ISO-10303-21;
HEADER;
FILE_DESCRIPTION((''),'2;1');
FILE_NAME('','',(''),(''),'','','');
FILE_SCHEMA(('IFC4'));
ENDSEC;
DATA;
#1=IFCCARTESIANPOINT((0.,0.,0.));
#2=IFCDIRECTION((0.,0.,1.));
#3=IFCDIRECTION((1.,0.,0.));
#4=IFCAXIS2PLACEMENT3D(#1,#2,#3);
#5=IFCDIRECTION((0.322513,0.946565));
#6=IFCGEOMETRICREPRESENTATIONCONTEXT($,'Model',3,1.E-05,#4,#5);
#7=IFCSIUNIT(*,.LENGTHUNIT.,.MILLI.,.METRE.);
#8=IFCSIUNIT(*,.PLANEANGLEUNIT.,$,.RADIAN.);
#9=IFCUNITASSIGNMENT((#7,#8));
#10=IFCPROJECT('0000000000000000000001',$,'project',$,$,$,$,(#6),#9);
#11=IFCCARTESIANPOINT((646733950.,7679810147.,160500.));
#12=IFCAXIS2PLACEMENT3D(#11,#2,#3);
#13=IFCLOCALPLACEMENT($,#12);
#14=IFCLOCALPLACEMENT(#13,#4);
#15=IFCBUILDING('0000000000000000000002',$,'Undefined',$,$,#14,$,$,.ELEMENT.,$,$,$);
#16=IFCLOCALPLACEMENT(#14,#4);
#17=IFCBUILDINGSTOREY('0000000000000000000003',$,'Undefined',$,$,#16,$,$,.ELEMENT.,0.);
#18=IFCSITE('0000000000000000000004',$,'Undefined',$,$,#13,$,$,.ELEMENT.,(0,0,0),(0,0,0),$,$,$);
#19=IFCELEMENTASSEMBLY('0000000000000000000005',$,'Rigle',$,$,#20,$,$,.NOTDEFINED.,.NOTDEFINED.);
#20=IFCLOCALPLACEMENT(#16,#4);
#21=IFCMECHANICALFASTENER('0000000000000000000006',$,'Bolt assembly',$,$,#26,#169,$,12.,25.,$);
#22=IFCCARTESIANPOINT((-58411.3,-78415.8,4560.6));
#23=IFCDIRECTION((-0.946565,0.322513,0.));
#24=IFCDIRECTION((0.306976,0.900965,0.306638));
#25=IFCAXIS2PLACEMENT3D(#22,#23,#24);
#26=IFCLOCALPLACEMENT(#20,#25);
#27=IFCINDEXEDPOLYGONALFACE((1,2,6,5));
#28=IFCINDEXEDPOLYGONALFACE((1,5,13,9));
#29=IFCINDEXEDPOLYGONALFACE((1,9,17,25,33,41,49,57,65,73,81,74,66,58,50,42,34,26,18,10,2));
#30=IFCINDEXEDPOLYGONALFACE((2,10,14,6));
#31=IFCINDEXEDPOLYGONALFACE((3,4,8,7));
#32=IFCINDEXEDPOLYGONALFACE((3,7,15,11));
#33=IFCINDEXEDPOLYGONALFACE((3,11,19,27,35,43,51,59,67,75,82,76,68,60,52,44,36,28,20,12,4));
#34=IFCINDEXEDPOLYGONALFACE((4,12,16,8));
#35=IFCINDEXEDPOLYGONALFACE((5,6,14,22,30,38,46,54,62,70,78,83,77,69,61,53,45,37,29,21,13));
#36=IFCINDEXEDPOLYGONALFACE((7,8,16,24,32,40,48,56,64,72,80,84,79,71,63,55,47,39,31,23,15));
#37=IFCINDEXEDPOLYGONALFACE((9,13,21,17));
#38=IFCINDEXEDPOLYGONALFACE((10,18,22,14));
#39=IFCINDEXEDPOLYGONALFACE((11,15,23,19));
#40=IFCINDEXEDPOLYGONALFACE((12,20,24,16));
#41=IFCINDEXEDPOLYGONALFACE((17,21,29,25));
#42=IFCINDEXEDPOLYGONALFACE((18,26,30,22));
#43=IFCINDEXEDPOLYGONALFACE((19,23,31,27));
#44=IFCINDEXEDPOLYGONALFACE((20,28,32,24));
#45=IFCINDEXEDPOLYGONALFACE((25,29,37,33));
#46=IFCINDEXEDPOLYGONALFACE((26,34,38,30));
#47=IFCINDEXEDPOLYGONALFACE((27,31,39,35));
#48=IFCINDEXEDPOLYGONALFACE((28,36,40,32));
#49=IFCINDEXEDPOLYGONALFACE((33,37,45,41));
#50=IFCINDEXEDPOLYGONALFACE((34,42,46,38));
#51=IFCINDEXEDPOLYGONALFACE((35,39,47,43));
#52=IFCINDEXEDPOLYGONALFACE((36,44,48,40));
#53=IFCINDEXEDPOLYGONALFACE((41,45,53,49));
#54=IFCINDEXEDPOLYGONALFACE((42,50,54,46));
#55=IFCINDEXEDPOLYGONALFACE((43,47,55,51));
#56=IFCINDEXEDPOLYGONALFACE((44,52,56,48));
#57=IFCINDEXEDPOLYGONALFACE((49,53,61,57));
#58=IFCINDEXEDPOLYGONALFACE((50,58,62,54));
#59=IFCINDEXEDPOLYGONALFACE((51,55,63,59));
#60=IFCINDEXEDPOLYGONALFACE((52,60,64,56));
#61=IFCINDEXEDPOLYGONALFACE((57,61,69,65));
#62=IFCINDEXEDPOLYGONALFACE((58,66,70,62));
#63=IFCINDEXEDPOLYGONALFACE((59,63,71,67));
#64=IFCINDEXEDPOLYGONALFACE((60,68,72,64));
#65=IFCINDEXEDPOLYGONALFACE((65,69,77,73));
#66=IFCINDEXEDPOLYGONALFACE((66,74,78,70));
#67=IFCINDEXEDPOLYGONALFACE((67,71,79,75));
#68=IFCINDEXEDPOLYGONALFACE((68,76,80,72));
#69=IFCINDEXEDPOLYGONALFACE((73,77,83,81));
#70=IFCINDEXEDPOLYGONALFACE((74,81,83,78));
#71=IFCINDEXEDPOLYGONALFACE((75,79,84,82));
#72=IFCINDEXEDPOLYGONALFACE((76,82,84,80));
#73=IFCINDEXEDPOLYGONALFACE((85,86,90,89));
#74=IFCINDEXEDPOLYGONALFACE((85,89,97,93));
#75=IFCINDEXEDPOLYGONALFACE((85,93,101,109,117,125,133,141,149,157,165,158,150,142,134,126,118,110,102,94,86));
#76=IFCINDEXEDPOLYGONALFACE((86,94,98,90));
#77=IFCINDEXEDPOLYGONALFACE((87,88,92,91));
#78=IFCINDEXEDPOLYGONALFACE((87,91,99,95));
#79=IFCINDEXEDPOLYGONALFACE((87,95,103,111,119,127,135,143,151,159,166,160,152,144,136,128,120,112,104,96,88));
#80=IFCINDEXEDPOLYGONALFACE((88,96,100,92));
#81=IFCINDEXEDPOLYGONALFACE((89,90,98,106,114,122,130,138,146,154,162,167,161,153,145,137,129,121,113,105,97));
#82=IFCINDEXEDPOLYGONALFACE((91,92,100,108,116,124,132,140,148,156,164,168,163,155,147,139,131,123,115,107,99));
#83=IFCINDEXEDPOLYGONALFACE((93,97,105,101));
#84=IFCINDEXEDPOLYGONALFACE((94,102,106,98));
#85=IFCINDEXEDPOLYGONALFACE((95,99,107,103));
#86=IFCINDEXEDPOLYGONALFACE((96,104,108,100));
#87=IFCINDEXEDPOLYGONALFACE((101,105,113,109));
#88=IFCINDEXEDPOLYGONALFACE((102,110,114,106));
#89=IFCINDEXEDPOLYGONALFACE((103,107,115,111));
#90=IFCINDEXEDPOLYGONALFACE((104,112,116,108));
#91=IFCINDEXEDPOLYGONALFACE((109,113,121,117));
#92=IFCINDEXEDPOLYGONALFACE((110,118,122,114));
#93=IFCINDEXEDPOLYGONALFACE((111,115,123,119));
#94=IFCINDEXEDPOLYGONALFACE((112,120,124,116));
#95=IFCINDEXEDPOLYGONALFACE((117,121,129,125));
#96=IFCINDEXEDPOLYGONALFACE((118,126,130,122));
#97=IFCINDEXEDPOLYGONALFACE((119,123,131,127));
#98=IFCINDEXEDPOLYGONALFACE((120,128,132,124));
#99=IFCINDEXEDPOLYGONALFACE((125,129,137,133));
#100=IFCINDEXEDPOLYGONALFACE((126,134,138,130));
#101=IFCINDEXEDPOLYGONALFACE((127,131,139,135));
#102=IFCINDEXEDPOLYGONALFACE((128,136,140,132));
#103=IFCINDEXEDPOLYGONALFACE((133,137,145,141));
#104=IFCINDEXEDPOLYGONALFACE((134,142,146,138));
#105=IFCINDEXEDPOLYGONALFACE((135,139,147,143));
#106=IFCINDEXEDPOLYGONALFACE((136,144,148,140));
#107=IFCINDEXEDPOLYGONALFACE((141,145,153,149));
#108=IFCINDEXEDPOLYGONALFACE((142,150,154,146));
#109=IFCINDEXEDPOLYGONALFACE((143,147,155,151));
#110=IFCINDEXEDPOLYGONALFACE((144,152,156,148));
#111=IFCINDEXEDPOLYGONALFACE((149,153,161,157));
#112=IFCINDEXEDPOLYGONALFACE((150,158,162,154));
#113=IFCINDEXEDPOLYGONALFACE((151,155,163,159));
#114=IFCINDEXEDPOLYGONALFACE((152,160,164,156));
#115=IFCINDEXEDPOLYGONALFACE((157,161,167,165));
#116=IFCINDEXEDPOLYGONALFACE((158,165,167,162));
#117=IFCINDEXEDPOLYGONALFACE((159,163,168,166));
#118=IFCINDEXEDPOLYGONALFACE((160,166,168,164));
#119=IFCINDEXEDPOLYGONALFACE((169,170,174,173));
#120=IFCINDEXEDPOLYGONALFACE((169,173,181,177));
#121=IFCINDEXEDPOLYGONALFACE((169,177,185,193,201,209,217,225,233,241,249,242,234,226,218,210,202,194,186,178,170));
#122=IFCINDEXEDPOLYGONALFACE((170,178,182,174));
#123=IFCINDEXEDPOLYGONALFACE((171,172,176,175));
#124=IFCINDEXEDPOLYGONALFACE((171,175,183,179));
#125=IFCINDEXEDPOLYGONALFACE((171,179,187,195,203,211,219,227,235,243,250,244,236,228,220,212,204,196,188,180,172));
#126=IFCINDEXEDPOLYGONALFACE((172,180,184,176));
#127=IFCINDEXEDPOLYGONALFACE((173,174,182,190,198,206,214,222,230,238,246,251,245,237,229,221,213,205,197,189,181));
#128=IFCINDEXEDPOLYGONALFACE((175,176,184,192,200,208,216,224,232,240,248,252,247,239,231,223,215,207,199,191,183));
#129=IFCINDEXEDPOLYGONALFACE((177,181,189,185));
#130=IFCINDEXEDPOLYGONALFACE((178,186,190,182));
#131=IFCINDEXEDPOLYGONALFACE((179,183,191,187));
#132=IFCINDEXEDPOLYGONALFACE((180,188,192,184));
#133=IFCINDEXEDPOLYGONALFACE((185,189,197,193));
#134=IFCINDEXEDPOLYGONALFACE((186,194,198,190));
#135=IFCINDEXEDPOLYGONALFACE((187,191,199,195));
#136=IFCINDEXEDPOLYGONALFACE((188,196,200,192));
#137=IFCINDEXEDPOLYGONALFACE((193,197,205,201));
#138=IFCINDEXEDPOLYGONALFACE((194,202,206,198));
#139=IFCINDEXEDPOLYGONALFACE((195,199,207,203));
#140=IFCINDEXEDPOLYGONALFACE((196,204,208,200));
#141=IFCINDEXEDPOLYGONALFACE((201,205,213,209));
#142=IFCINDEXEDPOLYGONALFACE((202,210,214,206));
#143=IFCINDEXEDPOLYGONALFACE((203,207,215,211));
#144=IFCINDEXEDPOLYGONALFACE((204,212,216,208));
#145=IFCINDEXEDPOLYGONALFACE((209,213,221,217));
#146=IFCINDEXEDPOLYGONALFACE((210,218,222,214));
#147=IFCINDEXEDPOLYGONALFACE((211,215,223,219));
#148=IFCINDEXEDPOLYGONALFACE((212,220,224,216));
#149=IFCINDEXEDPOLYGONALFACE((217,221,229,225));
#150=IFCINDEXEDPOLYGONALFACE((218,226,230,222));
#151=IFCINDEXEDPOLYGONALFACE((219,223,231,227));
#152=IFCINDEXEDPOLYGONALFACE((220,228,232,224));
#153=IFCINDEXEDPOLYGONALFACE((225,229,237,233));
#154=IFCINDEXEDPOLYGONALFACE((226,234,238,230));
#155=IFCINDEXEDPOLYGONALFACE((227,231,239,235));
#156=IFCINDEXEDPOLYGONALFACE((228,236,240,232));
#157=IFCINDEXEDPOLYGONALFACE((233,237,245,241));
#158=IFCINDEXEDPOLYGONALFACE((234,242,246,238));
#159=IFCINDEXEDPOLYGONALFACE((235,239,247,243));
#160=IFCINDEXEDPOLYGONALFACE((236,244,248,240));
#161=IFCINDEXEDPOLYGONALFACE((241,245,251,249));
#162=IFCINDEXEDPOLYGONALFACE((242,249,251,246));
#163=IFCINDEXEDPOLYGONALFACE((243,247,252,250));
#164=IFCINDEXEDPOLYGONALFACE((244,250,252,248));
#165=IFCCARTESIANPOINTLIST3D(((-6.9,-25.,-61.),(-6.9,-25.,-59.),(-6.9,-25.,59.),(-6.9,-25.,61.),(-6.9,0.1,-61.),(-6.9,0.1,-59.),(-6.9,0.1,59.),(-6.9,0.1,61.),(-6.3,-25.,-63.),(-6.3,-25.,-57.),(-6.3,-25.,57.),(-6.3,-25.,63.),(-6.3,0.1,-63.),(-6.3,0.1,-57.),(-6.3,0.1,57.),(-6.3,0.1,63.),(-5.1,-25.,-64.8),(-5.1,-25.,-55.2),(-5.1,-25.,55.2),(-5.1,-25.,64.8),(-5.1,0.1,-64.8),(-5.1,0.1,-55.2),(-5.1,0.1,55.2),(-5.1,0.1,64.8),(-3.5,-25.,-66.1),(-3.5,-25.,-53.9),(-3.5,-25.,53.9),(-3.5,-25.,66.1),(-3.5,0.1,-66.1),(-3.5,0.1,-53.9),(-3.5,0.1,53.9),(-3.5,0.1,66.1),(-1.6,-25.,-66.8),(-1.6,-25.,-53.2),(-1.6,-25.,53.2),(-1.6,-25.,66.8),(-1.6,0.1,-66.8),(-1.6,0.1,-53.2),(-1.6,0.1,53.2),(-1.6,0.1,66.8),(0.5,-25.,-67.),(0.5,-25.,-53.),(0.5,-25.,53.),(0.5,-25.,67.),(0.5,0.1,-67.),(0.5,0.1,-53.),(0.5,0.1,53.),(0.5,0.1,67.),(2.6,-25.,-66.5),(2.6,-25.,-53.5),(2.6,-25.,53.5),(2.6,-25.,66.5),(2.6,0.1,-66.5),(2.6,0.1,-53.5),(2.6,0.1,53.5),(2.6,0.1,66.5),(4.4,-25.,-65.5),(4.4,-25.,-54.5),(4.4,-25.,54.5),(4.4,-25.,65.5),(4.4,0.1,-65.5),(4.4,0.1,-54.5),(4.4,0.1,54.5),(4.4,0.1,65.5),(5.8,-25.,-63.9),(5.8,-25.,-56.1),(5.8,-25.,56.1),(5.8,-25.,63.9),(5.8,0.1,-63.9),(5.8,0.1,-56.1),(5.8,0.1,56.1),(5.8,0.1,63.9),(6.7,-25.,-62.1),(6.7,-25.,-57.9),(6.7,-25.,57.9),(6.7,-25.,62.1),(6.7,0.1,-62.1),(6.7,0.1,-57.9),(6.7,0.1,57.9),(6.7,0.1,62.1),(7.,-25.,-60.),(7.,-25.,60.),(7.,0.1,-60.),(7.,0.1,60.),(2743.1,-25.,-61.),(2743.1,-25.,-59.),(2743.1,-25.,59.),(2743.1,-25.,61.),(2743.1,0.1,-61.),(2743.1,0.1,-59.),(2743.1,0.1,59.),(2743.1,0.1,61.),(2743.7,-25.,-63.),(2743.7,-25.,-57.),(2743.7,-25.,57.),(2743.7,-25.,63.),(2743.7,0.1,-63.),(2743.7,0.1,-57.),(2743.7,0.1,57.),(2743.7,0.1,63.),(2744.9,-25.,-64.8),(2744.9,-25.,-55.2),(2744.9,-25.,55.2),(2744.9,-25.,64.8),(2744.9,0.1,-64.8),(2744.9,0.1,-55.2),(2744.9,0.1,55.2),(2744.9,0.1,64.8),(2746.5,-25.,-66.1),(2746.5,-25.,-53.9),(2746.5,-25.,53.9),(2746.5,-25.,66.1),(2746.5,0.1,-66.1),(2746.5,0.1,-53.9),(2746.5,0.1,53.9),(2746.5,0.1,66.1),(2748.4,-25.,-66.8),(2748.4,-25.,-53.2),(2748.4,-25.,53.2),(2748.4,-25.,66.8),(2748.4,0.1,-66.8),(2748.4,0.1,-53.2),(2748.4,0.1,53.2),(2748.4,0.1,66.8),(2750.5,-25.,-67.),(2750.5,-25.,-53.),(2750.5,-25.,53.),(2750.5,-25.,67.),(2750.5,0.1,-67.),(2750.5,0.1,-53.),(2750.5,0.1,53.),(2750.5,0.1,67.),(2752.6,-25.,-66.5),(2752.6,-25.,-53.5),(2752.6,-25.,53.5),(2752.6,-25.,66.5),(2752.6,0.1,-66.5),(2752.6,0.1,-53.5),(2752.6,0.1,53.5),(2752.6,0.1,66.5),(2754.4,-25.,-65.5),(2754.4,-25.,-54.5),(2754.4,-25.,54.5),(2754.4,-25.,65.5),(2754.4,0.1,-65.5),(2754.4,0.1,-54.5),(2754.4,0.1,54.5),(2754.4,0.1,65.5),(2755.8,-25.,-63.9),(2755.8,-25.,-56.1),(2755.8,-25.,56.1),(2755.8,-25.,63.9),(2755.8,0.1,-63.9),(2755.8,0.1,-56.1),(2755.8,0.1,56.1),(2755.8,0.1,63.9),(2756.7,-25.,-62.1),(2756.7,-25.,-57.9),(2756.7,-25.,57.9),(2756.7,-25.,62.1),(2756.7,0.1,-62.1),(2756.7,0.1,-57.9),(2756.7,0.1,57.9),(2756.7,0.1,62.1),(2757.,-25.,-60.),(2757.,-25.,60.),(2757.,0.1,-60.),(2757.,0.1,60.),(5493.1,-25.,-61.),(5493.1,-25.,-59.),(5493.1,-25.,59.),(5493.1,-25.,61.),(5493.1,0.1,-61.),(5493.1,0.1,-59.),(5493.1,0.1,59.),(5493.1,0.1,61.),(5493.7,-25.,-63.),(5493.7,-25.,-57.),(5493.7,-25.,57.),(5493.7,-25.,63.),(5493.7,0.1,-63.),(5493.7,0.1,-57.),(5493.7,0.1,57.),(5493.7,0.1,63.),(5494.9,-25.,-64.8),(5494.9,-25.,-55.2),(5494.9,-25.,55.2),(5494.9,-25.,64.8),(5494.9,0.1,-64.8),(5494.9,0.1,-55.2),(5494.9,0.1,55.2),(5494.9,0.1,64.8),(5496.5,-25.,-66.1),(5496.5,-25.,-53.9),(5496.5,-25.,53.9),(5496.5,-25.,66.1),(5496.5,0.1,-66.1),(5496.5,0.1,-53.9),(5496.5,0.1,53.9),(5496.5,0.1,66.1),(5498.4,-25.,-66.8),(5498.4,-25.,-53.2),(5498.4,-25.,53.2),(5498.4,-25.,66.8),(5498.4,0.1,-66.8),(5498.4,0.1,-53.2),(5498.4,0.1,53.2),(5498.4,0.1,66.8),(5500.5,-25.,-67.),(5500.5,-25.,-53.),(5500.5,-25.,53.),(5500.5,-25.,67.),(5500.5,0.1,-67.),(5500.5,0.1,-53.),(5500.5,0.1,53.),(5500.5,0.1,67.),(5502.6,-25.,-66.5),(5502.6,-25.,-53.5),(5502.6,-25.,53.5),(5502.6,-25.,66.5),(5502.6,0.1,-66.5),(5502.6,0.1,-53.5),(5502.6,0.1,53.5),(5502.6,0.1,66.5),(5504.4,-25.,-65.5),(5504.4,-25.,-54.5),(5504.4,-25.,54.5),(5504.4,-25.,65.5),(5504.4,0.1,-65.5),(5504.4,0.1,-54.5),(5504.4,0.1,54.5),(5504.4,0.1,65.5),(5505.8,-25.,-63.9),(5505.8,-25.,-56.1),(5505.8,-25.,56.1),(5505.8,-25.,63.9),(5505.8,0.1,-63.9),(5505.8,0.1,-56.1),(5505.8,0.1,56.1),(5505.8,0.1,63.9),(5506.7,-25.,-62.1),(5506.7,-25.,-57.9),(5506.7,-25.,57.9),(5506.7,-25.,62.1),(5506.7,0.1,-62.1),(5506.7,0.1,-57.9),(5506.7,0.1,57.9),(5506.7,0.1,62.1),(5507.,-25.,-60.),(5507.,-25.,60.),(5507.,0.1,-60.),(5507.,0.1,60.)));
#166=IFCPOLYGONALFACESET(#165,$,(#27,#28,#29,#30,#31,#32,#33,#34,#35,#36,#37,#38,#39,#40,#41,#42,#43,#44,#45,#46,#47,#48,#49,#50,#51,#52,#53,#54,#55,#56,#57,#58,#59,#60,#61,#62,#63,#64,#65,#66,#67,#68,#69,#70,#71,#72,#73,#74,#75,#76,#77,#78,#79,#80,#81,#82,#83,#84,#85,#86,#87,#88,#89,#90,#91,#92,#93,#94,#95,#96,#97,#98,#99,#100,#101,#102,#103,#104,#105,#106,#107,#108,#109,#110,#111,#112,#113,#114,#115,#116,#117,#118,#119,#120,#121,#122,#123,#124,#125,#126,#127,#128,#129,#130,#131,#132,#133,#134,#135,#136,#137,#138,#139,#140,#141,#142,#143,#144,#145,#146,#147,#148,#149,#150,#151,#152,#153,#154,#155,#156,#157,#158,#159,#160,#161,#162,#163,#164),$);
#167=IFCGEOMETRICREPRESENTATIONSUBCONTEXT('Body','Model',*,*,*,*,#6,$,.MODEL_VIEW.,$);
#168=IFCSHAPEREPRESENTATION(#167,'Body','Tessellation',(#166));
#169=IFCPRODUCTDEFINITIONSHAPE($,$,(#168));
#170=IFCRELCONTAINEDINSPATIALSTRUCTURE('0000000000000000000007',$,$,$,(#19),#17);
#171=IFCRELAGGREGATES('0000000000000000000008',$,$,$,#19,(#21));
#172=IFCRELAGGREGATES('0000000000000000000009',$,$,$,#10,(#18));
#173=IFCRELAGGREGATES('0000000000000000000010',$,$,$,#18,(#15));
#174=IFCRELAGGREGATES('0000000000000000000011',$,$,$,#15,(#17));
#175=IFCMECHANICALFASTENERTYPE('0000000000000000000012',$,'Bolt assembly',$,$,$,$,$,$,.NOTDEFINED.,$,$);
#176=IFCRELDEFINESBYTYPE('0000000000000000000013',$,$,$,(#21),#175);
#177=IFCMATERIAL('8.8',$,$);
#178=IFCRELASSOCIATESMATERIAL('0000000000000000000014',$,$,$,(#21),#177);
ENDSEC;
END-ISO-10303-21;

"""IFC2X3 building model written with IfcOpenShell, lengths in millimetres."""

from ifc_helpers import new_model, si_unit, direction, frame, origin_with_axes, origin_2d_with_axis, place, context, subcontext, project, spatial, circle, extrude, source, transform, mapped, material, type_object, element, aggregate, save


model = new_model("IFC2X3")

# Units and contexts
model_context = context("Model", 3, precision=1e-05, world=origin_with_axes(), true_north=direction((0.322513, 0.946565)))
body_context = subcontext(model_context, "Body", "Model", "MODEL_VIEW")
ifc_project = project(units=[si_unit("LENGTHUNIT", "METRE", prefix="MILLI"), si_unit("PLANEANGLEUNIT", "RADIAN")], contexts=[model_context])

# Site, building, storey
site_placement = place(None, frame((646733950.0, 7679810147.0, 160500.0), z_axis=(0.0, 0.0, 1.0), x_axis=(1.0, 0.0, 0.0)))
site = spatial("IfcSite", under=ifc_project, at=site_placement, Name="Undefined", CompositionType="ELEMENT", RefLatitude=(0, 0, 0), RefLongitude=(0, 0, 0))
building_placement = place(site_placement, origin_with_axes())
building = spatial("IfcBuilding", under=site, at=building_placement, Name="Undefined", CompositionType="ELEMENT")
storey_placement = place(building_placement, origin_with_axes())
storey = spatial("IfcBuildingStorey", under=building, at=storey_placement, Name="Undefined", CompositionType="ELEMENT", Elevation=0.0)

# Element assembly
assembly_1_placement = place(storey_placement, origin_with_axes())
assembly_1 = element("IfcElementAssembly", 1, at=assembly_1_placement, inside=storey, Name="Rigle", AssemblyPlace="NOTDEFINED", PredefinedType="NOTDEFINED")

# Shared definitions
ifc_material_1 = material(Name="8.8")
mechanical_fastener_type = type_object("IfcMechanicalFastenerType", Name="Bolt assembly")

# Mechanical fastener
shared_shape_1 = source(origin_with_axes(), body_context, "Body", "SweptSolid", [
    extrude(circle(Radius=7.0, at=origin_2d_with_axis()), frame((0.0, -25.0, 0.0), z_axis=(0.0, 1.0, 0.0), x_axis=(1.0, 0.0, 0.0)), (0.0, 0.0, 1.0), 25.1),
])
mechanical_fastener_1_placement = place(assembly_1_placement, frame((-58411.3, -78415.8, 4560.6), z_axis=(-0.946565, 0.322513, 0.0), x_axis=(0.306976, 0.900965, 0.306638)))
mechanical_fastener_1 = element("IfcMechanicalFastener", 2, at=mechanical_fastener_1_placement, type_object=mechanical_fastener_type, material=ifc_material_1, Name="Bolt assembly", NominalDiameter=12.0, NominalLength=25.0, context=body_context, shape_type="MappedRepresentation", body=[
    mapped(shared_shape_1, transform((0.0, 0.0, -60.0))),
    mapped(shared_shape_1, transform((2750.0, 0.0, -60.0))),
    mapped(shared_shape_1, transform((5500.0, 0.0, -60.0))),
    mapped(shared_shape_1, transform((0.0, 0.0, 60.0))),
    mapped(shared_shape_1, transform((2750.0, 0.0, 60.0))),
    mapped(shared_shape_1, transform((5500.0, 0.0, 60.0))),
])
aggregate(assembly_1, [mechanical_fastener_1])

save(model, "model.ifc")
